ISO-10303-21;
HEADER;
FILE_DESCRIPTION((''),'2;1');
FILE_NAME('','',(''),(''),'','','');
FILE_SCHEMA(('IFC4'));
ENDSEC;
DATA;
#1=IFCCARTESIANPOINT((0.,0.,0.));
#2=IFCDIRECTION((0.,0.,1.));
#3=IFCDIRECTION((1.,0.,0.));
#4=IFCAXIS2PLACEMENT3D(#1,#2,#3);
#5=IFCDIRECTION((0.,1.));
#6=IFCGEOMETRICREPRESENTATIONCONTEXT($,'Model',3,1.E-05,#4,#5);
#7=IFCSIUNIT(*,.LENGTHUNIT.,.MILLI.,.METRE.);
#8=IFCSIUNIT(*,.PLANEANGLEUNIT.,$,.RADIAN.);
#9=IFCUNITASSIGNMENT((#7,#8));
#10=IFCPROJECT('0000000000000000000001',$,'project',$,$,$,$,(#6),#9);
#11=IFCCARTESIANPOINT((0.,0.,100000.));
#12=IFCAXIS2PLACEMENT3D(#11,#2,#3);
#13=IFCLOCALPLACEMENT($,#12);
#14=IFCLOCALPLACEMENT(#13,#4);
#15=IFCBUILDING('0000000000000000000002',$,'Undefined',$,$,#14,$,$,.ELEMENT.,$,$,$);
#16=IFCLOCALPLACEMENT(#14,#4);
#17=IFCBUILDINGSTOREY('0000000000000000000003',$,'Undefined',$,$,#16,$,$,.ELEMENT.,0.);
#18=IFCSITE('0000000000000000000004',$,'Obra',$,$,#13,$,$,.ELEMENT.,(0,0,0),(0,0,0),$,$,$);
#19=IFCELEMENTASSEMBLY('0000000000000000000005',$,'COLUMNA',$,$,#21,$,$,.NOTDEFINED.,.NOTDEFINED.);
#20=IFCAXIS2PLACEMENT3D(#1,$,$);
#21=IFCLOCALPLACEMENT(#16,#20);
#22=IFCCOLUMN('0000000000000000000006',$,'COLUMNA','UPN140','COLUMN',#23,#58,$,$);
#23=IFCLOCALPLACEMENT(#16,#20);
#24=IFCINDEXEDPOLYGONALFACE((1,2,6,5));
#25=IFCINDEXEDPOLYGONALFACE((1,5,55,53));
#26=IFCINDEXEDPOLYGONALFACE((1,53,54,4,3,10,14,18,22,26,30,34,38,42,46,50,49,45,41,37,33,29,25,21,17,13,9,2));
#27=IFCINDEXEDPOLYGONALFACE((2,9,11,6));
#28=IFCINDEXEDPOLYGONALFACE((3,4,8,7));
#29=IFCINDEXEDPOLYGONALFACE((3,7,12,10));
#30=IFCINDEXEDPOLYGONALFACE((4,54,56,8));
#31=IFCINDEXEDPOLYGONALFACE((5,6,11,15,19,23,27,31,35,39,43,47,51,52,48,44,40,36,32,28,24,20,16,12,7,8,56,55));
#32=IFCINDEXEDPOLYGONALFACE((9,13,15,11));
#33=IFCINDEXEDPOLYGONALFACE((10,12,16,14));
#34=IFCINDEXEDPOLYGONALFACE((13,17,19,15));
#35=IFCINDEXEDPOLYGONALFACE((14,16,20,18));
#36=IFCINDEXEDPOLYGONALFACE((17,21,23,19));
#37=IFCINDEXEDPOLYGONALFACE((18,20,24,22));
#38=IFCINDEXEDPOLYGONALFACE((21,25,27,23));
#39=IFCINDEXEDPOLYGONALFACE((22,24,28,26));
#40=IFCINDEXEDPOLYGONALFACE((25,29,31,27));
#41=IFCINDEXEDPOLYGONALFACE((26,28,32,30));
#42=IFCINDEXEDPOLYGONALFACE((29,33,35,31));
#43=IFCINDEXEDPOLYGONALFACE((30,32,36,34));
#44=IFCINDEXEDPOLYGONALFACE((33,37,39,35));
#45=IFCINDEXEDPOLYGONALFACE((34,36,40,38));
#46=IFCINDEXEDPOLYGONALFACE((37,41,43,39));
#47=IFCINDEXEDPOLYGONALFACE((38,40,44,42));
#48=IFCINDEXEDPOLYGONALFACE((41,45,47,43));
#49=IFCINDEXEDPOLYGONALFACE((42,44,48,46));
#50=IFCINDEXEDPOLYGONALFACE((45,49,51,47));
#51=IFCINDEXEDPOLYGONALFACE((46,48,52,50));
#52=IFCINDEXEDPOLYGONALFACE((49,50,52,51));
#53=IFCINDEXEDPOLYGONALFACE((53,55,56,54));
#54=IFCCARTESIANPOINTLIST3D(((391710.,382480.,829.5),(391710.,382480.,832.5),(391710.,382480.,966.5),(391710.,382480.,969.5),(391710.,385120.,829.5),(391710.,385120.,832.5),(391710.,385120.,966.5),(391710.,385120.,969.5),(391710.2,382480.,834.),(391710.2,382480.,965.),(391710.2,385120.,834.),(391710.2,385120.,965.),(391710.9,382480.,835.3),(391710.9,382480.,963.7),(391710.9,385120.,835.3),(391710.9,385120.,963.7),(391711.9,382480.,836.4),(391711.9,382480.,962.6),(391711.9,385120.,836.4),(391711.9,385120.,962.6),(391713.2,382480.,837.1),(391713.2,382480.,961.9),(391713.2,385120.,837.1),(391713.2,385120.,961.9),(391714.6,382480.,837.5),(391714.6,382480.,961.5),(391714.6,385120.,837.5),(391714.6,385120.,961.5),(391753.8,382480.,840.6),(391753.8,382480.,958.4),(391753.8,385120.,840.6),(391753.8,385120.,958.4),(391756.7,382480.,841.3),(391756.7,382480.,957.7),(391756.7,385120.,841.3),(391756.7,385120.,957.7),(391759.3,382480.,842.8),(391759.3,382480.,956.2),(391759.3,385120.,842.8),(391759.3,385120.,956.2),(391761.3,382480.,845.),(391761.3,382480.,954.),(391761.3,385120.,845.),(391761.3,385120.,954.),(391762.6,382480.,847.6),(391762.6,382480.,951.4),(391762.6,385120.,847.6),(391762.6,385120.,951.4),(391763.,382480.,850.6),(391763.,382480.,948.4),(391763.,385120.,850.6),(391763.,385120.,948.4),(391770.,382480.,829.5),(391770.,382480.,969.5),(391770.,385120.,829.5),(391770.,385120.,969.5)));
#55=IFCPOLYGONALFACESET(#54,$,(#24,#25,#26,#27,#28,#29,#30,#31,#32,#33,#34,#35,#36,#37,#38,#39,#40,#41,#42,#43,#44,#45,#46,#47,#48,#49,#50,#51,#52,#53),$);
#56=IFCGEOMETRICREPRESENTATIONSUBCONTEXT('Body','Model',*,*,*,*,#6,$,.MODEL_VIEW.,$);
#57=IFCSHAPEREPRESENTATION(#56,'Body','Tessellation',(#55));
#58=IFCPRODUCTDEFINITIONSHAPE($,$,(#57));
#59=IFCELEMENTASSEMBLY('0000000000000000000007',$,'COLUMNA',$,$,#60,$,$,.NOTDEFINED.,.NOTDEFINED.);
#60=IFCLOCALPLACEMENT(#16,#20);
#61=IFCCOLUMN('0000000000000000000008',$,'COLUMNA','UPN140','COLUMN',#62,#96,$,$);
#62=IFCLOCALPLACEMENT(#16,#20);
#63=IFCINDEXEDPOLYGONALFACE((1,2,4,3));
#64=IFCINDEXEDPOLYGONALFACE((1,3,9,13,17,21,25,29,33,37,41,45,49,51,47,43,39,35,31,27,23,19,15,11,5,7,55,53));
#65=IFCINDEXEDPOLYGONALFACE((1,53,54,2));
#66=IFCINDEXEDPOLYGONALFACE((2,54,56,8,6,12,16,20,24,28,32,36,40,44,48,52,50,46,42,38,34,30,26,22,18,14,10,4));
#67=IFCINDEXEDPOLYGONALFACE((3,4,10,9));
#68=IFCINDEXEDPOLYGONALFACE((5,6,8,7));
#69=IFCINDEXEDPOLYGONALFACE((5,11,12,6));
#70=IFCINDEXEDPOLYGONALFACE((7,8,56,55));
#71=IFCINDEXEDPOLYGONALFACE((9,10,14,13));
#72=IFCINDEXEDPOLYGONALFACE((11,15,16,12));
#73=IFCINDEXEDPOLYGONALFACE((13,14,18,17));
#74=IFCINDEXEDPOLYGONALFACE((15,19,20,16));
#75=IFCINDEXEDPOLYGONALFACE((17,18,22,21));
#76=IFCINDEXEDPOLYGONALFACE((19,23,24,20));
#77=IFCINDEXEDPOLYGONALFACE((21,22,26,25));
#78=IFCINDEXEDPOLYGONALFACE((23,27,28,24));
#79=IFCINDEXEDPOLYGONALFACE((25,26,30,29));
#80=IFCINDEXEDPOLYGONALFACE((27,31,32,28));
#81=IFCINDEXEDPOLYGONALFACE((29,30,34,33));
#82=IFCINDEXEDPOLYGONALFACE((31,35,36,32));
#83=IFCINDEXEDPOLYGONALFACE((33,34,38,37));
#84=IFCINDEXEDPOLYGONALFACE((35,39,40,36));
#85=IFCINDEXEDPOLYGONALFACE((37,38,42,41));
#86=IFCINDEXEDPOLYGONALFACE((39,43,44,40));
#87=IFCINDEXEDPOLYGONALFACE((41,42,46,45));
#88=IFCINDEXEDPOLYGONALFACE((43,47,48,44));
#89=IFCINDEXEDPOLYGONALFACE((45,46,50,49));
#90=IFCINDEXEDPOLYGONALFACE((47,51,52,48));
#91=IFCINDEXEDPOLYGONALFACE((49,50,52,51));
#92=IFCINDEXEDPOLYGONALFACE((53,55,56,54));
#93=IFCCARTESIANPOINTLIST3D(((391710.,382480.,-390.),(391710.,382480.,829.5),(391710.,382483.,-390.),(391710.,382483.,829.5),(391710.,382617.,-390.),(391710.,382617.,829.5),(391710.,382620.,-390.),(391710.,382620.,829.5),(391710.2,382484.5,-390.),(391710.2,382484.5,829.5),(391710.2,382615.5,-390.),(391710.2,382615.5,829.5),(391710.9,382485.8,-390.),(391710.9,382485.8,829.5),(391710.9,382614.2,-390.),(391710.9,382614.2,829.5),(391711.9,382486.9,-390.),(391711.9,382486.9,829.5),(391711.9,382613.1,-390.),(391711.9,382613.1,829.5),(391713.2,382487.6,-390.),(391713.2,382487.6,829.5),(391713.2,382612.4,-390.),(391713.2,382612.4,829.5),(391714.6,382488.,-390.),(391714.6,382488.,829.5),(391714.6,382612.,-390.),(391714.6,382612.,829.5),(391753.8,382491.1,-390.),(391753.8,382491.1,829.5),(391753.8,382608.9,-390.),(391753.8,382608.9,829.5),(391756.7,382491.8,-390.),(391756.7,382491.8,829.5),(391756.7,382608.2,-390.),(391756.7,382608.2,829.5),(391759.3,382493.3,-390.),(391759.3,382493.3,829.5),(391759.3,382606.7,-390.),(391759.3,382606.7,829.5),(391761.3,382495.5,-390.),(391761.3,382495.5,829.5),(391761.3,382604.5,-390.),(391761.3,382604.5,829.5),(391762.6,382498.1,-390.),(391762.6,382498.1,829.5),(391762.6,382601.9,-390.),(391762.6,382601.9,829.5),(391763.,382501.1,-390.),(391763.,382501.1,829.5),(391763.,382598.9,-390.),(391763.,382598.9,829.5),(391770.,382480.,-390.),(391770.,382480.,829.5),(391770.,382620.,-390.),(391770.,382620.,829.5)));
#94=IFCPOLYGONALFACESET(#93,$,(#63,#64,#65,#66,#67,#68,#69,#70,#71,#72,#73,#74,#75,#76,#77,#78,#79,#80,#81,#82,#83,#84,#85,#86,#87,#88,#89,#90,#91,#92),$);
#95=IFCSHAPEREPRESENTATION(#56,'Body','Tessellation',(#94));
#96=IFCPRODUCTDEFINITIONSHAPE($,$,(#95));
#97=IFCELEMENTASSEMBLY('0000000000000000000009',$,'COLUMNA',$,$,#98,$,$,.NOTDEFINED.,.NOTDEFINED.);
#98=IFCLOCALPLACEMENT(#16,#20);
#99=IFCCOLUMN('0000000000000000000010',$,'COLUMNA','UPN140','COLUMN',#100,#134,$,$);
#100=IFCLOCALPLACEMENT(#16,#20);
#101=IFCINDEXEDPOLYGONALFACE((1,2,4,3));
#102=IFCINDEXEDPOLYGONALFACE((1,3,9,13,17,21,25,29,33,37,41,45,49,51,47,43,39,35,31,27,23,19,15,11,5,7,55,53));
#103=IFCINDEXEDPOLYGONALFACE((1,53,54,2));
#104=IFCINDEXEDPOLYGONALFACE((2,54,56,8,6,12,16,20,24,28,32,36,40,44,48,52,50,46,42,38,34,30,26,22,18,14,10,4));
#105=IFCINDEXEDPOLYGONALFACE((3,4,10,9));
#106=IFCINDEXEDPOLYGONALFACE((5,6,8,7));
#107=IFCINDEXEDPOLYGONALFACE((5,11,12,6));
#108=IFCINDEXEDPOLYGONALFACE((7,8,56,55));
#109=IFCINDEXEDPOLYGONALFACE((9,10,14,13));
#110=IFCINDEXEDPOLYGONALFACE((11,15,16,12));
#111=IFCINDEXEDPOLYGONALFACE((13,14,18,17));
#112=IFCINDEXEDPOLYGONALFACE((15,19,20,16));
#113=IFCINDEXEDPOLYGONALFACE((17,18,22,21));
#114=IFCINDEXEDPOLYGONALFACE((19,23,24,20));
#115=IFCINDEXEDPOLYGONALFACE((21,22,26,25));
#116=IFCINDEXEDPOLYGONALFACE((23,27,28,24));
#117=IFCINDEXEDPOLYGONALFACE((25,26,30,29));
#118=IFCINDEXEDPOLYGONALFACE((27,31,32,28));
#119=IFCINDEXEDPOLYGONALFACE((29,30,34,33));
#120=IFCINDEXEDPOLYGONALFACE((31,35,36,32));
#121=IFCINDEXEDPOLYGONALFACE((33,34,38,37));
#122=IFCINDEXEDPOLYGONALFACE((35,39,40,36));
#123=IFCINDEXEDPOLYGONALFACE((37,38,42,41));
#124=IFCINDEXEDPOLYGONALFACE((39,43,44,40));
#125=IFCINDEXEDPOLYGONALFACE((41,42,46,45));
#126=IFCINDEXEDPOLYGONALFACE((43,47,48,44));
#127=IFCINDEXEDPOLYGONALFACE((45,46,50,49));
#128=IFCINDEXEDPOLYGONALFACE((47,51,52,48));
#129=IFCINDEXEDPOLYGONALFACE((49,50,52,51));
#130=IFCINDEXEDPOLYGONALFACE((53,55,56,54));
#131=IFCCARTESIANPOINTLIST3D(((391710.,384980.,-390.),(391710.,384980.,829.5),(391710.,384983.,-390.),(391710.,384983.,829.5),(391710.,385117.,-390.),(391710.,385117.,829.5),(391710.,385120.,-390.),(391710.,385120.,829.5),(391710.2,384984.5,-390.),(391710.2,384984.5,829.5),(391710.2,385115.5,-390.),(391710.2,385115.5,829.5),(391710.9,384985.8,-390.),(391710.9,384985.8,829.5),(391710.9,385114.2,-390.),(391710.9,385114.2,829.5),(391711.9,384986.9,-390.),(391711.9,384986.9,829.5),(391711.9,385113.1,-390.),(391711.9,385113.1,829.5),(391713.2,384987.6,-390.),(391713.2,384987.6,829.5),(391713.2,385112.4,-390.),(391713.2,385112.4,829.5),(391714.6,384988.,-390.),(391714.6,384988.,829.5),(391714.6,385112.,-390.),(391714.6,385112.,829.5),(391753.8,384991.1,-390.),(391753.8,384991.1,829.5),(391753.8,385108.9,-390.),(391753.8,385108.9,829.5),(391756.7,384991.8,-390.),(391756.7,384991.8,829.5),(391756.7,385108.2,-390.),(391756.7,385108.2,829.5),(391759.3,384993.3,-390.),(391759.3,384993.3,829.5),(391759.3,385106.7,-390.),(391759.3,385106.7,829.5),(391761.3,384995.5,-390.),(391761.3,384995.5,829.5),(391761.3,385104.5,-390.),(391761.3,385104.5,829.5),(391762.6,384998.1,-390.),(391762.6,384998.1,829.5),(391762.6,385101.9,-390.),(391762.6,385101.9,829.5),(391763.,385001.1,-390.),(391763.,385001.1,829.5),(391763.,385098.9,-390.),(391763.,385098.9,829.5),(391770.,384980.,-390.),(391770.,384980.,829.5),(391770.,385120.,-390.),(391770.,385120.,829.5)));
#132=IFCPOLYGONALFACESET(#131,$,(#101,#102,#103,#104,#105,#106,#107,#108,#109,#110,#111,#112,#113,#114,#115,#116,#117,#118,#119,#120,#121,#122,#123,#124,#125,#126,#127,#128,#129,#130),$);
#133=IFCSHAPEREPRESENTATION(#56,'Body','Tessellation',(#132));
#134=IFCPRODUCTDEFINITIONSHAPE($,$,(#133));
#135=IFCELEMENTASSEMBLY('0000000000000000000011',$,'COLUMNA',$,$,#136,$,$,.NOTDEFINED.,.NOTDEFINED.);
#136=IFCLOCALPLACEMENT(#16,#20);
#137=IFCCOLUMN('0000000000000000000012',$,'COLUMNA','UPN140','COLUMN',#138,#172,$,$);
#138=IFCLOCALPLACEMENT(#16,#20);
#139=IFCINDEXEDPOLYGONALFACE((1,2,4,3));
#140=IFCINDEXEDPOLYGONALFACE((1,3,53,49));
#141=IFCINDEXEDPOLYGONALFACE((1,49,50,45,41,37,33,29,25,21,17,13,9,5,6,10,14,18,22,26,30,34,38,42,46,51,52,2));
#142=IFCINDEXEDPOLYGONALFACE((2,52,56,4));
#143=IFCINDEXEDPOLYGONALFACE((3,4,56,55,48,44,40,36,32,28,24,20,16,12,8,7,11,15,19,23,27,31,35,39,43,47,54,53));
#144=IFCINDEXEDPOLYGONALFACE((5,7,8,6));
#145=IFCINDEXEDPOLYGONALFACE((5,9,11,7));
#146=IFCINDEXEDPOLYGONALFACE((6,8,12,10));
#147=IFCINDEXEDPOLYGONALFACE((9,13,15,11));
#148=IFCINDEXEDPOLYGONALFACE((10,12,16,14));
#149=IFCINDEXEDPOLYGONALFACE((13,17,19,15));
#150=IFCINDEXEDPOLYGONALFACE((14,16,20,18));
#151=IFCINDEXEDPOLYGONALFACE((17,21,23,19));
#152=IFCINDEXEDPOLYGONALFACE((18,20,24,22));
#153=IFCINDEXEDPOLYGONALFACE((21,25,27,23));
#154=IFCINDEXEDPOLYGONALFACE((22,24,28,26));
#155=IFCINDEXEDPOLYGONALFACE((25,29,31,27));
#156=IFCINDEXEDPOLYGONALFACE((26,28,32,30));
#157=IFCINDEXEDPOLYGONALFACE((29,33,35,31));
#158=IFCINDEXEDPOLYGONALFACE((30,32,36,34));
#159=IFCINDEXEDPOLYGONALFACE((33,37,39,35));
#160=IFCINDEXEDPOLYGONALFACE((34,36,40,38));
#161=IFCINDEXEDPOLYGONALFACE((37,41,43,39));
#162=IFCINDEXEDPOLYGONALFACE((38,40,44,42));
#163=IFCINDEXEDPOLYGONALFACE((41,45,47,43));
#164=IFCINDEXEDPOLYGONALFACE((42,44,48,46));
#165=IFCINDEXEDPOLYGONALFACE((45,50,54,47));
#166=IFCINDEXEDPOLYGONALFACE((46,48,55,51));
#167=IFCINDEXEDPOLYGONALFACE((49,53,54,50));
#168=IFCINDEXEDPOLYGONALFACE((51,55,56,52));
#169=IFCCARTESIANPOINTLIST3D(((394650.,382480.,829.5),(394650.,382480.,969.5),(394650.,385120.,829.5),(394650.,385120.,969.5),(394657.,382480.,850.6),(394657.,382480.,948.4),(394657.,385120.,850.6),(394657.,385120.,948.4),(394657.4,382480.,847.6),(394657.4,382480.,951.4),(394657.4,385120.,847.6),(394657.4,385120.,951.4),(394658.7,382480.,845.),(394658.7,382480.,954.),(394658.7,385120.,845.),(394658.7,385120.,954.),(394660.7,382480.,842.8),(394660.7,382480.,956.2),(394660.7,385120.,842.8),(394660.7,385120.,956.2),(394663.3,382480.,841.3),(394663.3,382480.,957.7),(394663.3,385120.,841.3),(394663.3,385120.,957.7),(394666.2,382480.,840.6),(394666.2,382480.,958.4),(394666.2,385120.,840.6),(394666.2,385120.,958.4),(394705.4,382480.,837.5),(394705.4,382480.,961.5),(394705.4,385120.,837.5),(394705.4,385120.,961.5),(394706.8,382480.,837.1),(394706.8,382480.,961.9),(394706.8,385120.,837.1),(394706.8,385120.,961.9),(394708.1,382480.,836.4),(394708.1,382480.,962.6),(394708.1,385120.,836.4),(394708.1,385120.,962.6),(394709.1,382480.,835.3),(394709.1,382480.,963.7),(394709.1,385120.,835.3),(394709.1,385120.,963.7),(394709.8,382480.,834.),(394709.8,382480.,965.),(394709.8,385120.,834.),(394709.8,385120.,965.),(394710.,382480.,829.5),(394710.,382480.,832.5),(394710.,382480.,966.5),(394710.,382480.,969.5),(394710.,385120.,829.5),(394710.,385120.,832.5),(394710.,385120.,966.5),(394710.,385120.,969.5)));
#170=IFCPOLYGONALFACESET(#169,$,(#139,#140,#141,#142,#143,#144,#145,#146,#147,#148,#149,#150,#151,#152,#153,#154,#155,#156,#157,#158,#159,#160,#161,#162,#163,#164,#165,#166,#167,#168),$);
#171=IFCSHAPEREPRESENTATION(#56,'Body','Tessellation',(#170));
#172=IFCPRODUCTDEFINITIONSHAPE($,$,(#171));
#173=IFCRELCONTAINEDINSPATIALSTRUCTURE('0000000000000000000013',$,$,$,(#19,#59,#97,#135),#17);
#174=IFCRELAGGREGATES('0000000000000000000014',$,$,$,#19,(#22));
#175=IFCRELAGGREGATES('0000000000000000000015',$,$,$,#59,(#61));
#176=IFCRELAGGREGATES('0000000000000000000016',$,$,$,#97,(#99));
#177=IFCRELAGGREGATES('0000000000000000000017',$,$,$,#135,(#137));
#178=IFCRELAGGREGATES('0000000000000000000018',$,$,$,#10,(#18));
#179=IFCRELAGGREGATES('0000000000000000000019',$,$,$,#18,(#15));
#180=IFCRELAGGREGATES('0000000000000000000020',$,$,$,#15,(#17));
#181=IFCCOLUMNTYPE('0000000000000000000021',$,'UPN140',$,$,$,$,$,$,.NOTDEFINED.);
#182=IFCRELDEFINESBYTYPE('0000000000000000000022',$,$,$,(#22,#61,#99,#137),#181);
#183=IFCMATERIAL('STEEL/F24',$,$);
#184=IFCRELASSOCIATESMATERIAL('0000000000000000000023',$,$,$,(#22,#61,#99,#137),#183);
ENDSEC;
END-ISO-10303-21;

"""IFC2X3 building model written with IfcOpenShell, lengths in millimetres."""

from ifc_helpers import new_model, si_unit, direction, frame, origin_with_axes, origin_2d_with_axis, place, context, subcontext, project, spatial, u_section, extrude, material, type_object, element, aggregate, save


model = new_model("IFC2X3")

# Units and contexts
model_context = context("Model", 3, precision=1e-05, world=origin_with_axes(), true_north=direction((0.0, 1.0)))
body_context = subcontext(model_context, "Body", "Model", "MODEL_VIEW")
ifc_project = project(units=[si_unit("LENGTHUNIT", "METRE", prefix="MILLI"), si_unit("PLANEANGLEUNIT", "RADIAN")], contexts=[model_context])

# Site, building, storey
site_placement = place(None, frame((0.0, 0.0, 100000.0), z_axis=(0.0, 0.0, 1.0), x_axis=(1.0, 0.0, 0.0)))
site = spatial("IfcSite", under=ifc_project, at=site_placement, Name="Obra", CompositionType="ELEMENT", RefLatitude=(0, 0, 0), RefLongitude=(0, 0, 0))
building_placement = place(site_placement, origin_with_axes())
building = spatial("IfcBuilding", under=site, at=building_placement, Name="Undefined", CompositionType="ELEMENT")
storey_placement = place(building_placement, origin_with_axes())
storey = spatial("IfcBuildingStorey", under=building, at=storey_placement, Name="Undefined", CompositionType="ELEMENT", Elevation=0.0)

# Element assemblies, columns
assembly_1_placement = place(storey_placement, origin_with_axes())
assembly_1 = element("IfcElementAssembly", 1, at=assembly_1_placement, inside=storey, Name="COLUMNA", AssemblyPlace="NOTDEFINED", PredefinedType="NOTDEFINED")
ifc_material_1 = material(Name="STEEL/F24")
column_type_1 = type_object("IfcColumnType", Name="UPN140", PredefinedType="NOTDEFINED")
column_1_placement = place(assembly_1_placement, frame((391740.0, 385120.0, 899.5), z_axis=(0.0, -1.0, 0.0), x_axis=(0.0, 0.0, 1.0)))
column_1 = element("IfcColumn", 2, at=column_1_placement, type_object=column_type_1, material=ifc_material_1, Name="COLUMNA", Description="UPN140", ObjectType="COLUMN", context=body_context, shape_type="SweptSolid", body=[
    extrude(u_section(Depth=140.0, FlangeWidth=60.0, WebThickness=7.0, FlangeThickness=10.0, FilletRadius=10.0, EdgeRadius=5.0, FlangeSlope=0.07983, at=origin_2d_with_axis()), frame((0.0, 0.0, 2640.0), z_axis=(0.0, 0.0, -1.0), x_axis=(0.0, 1.0, 0.0)), (0.0, 0.0, 1.0), 2640.0),
])
aggregate(assembly_1, [column_1])
assembly_2_placement = place(storey_placement, origin_with_axes())
assembly_2 = element("IfcElementAssembly", 3, at=assembly_2_placement, inside=storey, Name="COLUMNA", AssemblyPlace="NOTDEFINED", PredefinedType="NOTDEFINED")
column_2_placement = place(assembly_2_placement, frame((391740.0, 382550.0, -390.0), z_axis=(0.0, 0.0, 1.0), x_axis=(0.0, 1.0, 0.0)))
column_2 = element("IfcColumn", 4, at=column_2_placement, type_object=column_type_1, material=ifc_material_1, Name="COLUMNA", Description="UPN140", ObjectType="COLUMN", context=body_context, shape_type="SweptSolid", body=[
    extrude(u_section(Depth=140.0, FlangeWidth=60.0, WebThickness=7.0, FlangeThickness=10.0, FilletRadius=10.0, EdgeRadius=5.0, FlangeSlope=0.07983, at=origin_2d_with_axis()), frame((0.0, 0.0, 1219.5), z_axis=(0.0, 0.0, -1.0), x_axis=(0.0, 1.0, 0.0)), (0.0, 0.0, 1.0), 1219.5),
])
aggregate(assembly_2, [column_2])
assembly_3_placement = place(storey_placement, origin_with_axes())
assembly_3 = element("IfcElementAssembly", 5, at=assembly_3_placement, inside=storey, Name="COLUMNA", AssemblyPlace="NOTDEFINED", PredefinedType="NOTDEFINED")
column_3_placement = place(assembly_3_placement, frame((391740.0, 385050.0, -390.0), z_axis=(0.0, 0.0, 1.0), x_axis=(0.0, 1.0, 0.0)))
column_3 = element("IfcColumn", 6, at=column_3_placement, type_object=column_type_1, material=ifc_material_1, Name="COLUMNA", Description="UPN140", ObjectType="COLUMN", context=body_context, shape_type="SweptSolid", body=[
    extrude(u_section(Depth=140.0, FlangeWidth=60.0, WebThickness=7.0, FlangeThickness=10.0, FilletRadius=10.0, EdgeRadius=5.0, FlangeSlope=0.07983, at=origin_2d_with_axis()), frame((0.0, 0.0, 1219.5), z_axis=(0.0, 0.0, -1.0), x_axis=(0.0, 1.0, 0.0)), (0.0, 0.0, 1.0), 1219.5),
])
aggregate(assembly_3, [column_3])
assembly_4_placement = place(storey_placement, origin_with_axes())
assembly_4 = element("IfcElementAssembly", 7, at=assembly_4_placement, inside=storey, Name="COLUMNA", AssemblyPlace="NOTDEFINED", PredefinedType="NOTDEFINED")
column_4_placement = place(assembly_4_placement, frame((394680.0, 385120.0, 899.5), z_axis=(0.0, -1.0, 0.0), x_axis=(0.0, 0.0, -1.0)))
column_4 = element("IfcColumn", 8, at=column_4_placement, type_object=column_type_1, material=ifc_material_1, Name="COLUMNA", Description="UPN140", ObjectType="COLUMN", context=body_context, shape_type="SweptSolid", body=[
    extrude(u_section(Depth=140.0, FlangeWidth=60.0, WebThickness=7.0, FlangeThickness=10.0, FilletRadius=10.0, EdgeRadius=5.0, FlangeSlope=0.07983, at=origin_2d_with_axis()), frame((0.0, 0.0, 2640.0), z_axis=(0.0, 0.0, -1.0), x_axis=(0.0, 1.0, 0.0)), (0.0, 0.0, 1.0), 2640.0),
])
aggregate(assembly_4, [column_4])

save(model, "model.ifc")
